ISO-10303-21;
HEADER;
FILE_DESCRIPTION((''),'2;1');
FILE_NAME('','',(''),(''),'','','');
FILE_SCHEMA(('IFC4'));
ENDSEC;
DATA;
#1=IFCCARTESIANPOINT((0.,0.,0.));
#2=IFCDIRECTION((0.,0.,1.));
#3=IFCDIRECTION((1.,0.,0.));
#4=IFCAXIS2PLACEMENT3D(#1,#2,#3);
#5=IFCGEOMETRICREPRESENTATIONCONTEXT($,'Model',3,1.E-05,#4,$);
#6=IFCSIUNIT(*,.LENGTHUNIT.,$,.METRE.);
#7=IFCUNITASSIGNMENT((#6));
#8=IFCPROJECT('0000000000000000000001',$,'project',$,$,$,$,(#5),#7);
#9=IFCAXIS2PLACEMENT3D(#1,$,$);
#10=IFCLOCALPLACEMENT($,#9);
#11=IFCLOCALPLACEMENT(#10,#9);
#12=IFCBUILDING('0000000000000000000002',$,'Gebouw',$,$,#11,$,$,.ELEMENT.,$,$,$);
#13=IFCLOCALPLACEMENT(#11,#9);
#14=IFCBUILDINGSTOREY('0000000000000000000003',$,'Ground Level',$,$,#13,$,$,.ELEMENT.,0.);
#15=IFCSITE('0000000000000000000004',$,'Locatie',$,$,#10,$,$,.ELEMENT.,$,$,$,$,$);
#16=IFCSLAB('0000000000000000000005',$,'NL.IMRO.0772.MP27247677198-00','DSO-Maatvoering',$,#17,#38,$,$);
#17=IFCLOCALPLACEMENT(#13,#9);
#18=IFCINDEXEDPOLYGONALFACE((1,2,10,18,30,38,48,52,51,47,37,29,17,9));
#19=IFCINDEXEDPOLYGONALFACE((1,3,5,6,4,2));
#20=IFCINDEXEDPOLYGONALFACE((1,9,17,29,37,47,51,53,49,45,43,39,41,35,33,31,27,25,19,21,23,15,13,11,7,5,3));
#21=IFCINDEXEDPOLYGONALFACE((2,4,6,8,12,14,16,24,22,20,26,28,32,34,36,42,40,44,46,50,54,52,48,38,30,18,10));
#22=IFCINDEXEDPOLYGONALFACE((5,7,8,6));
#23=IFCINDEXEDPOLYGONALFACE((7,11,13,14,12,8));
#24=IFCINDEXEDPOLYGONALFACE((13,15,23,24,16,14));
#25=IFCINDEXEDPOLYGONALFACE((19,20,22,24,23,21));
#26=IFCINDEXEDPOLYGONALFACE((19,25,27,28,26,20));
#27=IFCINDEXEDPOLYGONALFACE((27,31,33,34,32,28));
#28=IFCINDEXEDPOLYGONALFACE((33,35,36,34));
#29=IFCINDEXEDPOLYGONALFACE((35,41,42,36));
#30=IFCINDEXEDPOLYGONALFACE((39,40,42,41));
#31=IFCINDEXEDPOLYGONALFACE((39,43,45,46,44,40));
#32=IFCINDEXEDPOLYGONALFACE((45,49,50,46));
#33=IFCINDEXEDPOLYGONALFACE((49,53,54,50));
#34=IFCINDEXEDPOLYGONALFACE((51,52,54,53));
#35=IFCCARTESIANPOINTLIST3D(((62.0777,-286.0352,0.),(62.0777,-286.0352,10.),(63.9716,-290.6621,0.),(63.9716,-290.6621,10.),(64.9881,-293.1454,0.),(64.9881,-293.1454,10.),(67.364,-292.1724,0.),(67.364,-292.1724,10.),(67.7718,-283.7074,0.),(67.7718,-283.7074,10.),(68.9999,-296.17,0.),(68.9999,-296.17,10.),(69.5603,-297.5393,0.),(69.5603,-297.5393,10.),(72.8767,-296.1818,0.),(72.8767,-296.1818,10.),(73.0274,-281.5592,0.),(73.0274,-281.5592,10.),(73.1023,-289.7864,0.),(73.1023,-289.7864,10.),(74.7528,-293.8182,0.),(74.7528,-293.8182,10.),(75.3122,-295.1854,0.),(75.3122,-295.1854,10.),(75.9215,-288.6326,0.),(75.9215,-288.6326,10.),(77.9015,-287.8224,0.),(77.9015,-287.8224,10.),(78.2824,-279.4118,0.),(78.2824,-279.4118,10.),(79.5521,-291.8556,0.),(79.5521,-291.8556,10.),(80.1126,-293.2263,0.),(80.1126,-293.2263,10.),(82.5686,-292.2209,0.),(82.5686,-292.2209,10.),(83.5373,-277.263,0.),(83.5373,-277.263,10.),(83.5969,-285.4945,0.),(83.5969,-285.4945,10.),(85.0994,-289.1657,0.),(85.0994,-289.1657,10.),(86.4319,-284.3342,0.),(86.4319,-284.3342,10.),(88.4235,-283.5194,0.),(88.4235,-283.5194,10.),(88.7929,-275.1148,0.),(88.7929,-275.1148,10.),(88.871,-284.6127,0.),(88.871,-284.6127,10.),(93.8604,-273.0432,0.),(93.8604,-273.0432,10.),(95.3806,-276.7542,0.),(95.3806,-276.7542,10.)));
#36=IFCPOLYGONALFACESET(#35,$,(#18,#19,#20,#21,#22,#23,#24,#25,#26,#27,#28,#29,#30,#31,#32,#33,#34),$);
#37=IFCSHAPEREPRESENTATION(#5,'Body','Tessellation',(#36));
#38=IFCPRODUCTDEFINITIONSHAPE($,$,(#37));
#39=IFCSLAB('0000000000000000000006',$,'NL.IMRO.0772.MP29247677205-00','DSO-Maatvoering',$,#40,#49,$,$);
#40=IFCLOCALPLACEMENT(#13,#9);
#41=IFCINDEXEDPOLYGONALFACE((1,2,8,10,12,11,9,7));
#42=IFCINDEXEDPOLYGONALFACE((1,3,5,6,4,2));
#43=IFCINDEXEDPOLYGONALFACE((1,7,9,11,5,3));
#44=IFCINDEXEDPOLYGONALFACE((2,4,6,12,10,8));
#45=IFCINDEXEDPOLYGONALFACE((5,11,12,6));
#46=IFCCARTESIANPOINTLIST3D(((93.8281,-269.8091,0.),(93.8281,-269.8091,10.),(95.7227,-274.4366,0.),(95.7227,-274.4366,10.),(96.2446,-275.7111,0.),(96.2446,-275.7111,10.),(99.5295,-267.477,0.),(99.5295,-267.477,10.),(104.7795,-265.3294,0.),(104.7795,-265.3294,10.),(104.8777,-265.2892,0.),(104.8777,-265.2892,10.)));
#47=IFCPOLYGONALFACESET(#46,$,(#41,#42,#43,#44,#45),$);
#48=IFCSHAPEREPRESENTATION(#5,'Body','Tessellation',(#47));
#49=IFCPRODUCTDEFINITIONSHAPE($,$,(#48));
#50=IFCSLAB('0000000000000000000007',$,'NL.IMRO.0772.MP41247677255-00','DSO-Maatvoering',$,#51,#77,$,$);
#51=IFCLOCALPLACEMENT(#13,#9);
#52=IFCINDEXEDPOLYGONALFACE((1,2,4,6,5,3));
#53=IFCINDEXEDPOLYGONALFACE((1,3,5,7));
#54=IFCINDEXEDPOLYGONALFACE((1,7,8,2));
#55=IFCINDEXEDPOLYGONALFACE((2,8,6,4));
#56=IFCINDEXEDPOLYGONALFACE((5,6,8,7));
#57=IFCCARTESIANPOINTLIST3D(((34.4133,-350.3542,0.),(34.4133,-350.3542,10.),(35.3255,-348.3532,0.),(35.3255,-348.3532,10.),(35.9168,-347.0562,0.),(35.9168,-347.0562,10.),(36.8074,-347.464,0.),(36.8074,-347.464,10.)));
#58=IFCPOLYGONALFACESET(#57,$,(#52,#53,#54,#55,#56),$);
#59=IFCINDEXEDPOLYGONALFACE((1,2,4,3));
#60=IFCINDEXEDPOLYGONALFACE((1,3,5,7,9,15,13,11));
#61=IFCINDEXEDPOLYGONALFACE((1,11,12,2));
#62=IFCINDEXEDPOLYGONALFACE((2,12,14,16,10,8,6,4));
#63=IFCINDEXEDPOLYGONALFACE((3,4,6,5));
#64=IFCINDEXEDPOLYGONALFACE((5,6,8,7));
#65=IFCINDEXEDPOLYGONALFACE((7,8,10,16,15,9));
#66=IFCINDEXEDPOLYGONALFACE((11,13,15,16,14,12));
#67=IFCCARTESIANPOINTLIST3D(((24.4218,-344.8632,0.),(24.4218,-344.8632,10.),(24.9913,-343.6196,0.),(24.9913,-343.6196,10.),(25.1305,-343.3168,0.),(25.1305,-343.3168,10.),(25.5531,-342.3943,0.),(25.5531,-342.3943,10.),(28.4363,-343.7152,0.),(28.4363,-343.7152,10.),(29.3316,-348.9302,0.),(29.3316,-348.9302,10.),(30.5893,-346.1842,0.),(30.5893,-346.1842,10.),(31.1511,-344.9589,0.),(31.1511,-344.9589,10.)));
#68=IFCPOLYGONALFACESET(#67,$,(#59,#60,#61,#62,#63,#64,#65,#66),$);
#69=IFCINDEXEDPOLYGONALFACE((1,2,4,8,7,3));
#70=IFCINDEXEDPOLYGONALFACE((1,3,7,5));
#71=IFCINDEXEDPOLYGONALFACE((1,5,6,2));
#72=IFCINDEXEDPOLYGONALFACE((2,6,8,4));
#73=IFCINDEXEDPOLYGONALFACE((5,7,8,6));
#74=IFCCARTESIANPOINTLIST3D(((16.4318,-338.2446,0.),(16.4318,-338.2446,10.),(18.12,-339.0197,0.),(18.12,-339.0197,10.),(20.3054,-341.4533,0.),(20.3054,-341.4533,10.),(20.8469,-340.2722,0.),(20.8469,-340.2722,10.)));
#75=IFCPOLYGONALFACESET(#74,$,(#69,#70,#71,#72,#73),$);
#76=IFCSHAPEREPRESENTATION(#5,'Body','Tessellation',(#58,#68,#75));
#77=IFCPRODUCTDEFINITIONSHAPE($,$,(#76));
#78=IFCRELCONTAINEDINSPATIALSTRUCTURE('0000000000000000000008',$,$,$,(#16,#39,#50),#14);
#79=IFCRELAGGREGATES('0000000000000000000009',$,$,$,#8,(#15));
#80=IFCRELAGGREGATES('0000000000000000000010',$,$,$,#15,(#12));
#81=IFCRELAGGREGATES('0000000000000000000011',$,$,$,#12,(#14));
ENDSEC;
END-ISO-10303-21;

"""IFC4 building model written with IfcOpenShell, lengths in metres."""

from ifc_helpers import new_model, si_unit, origin, origin_with_axes, place, context, project, spatial, polyline, outline, extrude, element, save


model = new_model("IFC4")

# Units and contexts
model_context = context("Model", 3, precision=1e-05, world=origin_with_axes())
ifc_project = project(units=[si_unit("LENGTHUNIT", "METRE")], contexts=[model_context])

# Site, building, storey
site_placement = place(None, origin())
site = spatial("IfcSite", under=ifc_project, at=site_placement, Name="Locatie", CompositionType="ELEMENT")
building_placement = place(site_placement, origin())
building = spatial("IfcBuilding", under=site, at=building_placement, Name="Gebouw", CompositionType="ELEMENT")
storey_placement = place(building_placement, origin())
storey = spatial("IfcBuildingStorey", under=building, at=storey_placement, Name="Ground Level", CompositionType="ELEMENT", Elevation=0.0)

# Slabs
slab_1_placement = place(storey_placement, origin())
element("IfcSlab", 1, at=slab_1_placement, inside=storey, Name="NL.IMRO.0772.MP27247677198-00", Description="DSO-Maatvoering", context=model_context, shape_type="SweptSolid", body=[
    extrude(outline(polyline([(80.1126, -293.2263), (79.5521, -291.8556), (77.9015, -287.8224), (75.9215, -288.6326), (73.1023, -289.7864), (74.7528, -293.8182), (75.3122, -295.1854), (72.8767, -296.1818), (69.5603, -297.5393), (68.9999, -296.17), (67.364, -292.1724), (64.9881, -293.1454), (63.9716, -290.6621), (62.0777, -286.0352), (67.7718, -283.7074), (73.0274, -281.5592), (78.2824, -279.4118), (83.5373, -277.263), (88.7929, -275.1148), (93.8604, -273.0432), (95.3806, -276.7542), (88.871, -284.6127), (88.4235, -283.5194), (86.4319, -284.3342), (83.5969, -285.4945), (85.0994, -289.1657), (82.5686, -292.2209), (80.1126, -293.2263)])), origin_with_axes(), (0.0, 0.0, 1.0), 10.0),
])
slab_2_placement = place(storey_placement, origin())
element("IfcSlab", 2, at=slab_2_placement, inside=storey, Name="NL.IMRO.0772.MP29247677205-00", Description="DSO-Maatvoering", context=model_context, shape_type="SweptSolid", body=[
    extrude(outline(polyline([(95.7227, -274.4366), (93.8281, -269.8091), (99.5295, -267.477), (104.7795, -265.3294), (104.8777, -265.2892), (96.2446, -275.7111), (95.7227, -274.4366)])), origin_with_axes(), (0.0, 0.0, 1.0), 10.0),
])
slab_3_placement = place(storey_placement, origin())
element("IfcSlab", 3, at=slab_3_placement, inside=storey, Name="NL.IMRO.0772.MP41247677255-00", Description="DSO-Maatvoering", context=model_context, shape_type="SweptSolid", body=[
    extrude(outline(polyline([(35.3255, -348.3532), (35.9168, -347.0562), (36.8074, -347.464), (34.4133, -350.3542), (35.3255, -348.3532)])), origin_with_axes(), (0.0, 0.0, 1.0), 10.0),
    extrude(outline(polyline([(24.9913, -343.6196), (25.1305, -343.3168), (25.5531, -342.3943), (28.4363, -343.7152), (31.1511, -344.9589), (30.5893, -346.1842), (29.3316, -348.9302), (24.4218, -344.8632), (24.9913, -343.6196)])), origin_with_axes(), (0.0, 0.0, 1.0), 10.0),
    extrude(outline(polyline([(18.12, -339.0197), (20.8469, -340.2722), (20.3054, -341.4533), (16.4318, -338.2446), (18.12, -339.0197)])), origin_with_axes(), (0.0, 0.0, 1.0), 10.0),
])

save(model, "model.ifc")
